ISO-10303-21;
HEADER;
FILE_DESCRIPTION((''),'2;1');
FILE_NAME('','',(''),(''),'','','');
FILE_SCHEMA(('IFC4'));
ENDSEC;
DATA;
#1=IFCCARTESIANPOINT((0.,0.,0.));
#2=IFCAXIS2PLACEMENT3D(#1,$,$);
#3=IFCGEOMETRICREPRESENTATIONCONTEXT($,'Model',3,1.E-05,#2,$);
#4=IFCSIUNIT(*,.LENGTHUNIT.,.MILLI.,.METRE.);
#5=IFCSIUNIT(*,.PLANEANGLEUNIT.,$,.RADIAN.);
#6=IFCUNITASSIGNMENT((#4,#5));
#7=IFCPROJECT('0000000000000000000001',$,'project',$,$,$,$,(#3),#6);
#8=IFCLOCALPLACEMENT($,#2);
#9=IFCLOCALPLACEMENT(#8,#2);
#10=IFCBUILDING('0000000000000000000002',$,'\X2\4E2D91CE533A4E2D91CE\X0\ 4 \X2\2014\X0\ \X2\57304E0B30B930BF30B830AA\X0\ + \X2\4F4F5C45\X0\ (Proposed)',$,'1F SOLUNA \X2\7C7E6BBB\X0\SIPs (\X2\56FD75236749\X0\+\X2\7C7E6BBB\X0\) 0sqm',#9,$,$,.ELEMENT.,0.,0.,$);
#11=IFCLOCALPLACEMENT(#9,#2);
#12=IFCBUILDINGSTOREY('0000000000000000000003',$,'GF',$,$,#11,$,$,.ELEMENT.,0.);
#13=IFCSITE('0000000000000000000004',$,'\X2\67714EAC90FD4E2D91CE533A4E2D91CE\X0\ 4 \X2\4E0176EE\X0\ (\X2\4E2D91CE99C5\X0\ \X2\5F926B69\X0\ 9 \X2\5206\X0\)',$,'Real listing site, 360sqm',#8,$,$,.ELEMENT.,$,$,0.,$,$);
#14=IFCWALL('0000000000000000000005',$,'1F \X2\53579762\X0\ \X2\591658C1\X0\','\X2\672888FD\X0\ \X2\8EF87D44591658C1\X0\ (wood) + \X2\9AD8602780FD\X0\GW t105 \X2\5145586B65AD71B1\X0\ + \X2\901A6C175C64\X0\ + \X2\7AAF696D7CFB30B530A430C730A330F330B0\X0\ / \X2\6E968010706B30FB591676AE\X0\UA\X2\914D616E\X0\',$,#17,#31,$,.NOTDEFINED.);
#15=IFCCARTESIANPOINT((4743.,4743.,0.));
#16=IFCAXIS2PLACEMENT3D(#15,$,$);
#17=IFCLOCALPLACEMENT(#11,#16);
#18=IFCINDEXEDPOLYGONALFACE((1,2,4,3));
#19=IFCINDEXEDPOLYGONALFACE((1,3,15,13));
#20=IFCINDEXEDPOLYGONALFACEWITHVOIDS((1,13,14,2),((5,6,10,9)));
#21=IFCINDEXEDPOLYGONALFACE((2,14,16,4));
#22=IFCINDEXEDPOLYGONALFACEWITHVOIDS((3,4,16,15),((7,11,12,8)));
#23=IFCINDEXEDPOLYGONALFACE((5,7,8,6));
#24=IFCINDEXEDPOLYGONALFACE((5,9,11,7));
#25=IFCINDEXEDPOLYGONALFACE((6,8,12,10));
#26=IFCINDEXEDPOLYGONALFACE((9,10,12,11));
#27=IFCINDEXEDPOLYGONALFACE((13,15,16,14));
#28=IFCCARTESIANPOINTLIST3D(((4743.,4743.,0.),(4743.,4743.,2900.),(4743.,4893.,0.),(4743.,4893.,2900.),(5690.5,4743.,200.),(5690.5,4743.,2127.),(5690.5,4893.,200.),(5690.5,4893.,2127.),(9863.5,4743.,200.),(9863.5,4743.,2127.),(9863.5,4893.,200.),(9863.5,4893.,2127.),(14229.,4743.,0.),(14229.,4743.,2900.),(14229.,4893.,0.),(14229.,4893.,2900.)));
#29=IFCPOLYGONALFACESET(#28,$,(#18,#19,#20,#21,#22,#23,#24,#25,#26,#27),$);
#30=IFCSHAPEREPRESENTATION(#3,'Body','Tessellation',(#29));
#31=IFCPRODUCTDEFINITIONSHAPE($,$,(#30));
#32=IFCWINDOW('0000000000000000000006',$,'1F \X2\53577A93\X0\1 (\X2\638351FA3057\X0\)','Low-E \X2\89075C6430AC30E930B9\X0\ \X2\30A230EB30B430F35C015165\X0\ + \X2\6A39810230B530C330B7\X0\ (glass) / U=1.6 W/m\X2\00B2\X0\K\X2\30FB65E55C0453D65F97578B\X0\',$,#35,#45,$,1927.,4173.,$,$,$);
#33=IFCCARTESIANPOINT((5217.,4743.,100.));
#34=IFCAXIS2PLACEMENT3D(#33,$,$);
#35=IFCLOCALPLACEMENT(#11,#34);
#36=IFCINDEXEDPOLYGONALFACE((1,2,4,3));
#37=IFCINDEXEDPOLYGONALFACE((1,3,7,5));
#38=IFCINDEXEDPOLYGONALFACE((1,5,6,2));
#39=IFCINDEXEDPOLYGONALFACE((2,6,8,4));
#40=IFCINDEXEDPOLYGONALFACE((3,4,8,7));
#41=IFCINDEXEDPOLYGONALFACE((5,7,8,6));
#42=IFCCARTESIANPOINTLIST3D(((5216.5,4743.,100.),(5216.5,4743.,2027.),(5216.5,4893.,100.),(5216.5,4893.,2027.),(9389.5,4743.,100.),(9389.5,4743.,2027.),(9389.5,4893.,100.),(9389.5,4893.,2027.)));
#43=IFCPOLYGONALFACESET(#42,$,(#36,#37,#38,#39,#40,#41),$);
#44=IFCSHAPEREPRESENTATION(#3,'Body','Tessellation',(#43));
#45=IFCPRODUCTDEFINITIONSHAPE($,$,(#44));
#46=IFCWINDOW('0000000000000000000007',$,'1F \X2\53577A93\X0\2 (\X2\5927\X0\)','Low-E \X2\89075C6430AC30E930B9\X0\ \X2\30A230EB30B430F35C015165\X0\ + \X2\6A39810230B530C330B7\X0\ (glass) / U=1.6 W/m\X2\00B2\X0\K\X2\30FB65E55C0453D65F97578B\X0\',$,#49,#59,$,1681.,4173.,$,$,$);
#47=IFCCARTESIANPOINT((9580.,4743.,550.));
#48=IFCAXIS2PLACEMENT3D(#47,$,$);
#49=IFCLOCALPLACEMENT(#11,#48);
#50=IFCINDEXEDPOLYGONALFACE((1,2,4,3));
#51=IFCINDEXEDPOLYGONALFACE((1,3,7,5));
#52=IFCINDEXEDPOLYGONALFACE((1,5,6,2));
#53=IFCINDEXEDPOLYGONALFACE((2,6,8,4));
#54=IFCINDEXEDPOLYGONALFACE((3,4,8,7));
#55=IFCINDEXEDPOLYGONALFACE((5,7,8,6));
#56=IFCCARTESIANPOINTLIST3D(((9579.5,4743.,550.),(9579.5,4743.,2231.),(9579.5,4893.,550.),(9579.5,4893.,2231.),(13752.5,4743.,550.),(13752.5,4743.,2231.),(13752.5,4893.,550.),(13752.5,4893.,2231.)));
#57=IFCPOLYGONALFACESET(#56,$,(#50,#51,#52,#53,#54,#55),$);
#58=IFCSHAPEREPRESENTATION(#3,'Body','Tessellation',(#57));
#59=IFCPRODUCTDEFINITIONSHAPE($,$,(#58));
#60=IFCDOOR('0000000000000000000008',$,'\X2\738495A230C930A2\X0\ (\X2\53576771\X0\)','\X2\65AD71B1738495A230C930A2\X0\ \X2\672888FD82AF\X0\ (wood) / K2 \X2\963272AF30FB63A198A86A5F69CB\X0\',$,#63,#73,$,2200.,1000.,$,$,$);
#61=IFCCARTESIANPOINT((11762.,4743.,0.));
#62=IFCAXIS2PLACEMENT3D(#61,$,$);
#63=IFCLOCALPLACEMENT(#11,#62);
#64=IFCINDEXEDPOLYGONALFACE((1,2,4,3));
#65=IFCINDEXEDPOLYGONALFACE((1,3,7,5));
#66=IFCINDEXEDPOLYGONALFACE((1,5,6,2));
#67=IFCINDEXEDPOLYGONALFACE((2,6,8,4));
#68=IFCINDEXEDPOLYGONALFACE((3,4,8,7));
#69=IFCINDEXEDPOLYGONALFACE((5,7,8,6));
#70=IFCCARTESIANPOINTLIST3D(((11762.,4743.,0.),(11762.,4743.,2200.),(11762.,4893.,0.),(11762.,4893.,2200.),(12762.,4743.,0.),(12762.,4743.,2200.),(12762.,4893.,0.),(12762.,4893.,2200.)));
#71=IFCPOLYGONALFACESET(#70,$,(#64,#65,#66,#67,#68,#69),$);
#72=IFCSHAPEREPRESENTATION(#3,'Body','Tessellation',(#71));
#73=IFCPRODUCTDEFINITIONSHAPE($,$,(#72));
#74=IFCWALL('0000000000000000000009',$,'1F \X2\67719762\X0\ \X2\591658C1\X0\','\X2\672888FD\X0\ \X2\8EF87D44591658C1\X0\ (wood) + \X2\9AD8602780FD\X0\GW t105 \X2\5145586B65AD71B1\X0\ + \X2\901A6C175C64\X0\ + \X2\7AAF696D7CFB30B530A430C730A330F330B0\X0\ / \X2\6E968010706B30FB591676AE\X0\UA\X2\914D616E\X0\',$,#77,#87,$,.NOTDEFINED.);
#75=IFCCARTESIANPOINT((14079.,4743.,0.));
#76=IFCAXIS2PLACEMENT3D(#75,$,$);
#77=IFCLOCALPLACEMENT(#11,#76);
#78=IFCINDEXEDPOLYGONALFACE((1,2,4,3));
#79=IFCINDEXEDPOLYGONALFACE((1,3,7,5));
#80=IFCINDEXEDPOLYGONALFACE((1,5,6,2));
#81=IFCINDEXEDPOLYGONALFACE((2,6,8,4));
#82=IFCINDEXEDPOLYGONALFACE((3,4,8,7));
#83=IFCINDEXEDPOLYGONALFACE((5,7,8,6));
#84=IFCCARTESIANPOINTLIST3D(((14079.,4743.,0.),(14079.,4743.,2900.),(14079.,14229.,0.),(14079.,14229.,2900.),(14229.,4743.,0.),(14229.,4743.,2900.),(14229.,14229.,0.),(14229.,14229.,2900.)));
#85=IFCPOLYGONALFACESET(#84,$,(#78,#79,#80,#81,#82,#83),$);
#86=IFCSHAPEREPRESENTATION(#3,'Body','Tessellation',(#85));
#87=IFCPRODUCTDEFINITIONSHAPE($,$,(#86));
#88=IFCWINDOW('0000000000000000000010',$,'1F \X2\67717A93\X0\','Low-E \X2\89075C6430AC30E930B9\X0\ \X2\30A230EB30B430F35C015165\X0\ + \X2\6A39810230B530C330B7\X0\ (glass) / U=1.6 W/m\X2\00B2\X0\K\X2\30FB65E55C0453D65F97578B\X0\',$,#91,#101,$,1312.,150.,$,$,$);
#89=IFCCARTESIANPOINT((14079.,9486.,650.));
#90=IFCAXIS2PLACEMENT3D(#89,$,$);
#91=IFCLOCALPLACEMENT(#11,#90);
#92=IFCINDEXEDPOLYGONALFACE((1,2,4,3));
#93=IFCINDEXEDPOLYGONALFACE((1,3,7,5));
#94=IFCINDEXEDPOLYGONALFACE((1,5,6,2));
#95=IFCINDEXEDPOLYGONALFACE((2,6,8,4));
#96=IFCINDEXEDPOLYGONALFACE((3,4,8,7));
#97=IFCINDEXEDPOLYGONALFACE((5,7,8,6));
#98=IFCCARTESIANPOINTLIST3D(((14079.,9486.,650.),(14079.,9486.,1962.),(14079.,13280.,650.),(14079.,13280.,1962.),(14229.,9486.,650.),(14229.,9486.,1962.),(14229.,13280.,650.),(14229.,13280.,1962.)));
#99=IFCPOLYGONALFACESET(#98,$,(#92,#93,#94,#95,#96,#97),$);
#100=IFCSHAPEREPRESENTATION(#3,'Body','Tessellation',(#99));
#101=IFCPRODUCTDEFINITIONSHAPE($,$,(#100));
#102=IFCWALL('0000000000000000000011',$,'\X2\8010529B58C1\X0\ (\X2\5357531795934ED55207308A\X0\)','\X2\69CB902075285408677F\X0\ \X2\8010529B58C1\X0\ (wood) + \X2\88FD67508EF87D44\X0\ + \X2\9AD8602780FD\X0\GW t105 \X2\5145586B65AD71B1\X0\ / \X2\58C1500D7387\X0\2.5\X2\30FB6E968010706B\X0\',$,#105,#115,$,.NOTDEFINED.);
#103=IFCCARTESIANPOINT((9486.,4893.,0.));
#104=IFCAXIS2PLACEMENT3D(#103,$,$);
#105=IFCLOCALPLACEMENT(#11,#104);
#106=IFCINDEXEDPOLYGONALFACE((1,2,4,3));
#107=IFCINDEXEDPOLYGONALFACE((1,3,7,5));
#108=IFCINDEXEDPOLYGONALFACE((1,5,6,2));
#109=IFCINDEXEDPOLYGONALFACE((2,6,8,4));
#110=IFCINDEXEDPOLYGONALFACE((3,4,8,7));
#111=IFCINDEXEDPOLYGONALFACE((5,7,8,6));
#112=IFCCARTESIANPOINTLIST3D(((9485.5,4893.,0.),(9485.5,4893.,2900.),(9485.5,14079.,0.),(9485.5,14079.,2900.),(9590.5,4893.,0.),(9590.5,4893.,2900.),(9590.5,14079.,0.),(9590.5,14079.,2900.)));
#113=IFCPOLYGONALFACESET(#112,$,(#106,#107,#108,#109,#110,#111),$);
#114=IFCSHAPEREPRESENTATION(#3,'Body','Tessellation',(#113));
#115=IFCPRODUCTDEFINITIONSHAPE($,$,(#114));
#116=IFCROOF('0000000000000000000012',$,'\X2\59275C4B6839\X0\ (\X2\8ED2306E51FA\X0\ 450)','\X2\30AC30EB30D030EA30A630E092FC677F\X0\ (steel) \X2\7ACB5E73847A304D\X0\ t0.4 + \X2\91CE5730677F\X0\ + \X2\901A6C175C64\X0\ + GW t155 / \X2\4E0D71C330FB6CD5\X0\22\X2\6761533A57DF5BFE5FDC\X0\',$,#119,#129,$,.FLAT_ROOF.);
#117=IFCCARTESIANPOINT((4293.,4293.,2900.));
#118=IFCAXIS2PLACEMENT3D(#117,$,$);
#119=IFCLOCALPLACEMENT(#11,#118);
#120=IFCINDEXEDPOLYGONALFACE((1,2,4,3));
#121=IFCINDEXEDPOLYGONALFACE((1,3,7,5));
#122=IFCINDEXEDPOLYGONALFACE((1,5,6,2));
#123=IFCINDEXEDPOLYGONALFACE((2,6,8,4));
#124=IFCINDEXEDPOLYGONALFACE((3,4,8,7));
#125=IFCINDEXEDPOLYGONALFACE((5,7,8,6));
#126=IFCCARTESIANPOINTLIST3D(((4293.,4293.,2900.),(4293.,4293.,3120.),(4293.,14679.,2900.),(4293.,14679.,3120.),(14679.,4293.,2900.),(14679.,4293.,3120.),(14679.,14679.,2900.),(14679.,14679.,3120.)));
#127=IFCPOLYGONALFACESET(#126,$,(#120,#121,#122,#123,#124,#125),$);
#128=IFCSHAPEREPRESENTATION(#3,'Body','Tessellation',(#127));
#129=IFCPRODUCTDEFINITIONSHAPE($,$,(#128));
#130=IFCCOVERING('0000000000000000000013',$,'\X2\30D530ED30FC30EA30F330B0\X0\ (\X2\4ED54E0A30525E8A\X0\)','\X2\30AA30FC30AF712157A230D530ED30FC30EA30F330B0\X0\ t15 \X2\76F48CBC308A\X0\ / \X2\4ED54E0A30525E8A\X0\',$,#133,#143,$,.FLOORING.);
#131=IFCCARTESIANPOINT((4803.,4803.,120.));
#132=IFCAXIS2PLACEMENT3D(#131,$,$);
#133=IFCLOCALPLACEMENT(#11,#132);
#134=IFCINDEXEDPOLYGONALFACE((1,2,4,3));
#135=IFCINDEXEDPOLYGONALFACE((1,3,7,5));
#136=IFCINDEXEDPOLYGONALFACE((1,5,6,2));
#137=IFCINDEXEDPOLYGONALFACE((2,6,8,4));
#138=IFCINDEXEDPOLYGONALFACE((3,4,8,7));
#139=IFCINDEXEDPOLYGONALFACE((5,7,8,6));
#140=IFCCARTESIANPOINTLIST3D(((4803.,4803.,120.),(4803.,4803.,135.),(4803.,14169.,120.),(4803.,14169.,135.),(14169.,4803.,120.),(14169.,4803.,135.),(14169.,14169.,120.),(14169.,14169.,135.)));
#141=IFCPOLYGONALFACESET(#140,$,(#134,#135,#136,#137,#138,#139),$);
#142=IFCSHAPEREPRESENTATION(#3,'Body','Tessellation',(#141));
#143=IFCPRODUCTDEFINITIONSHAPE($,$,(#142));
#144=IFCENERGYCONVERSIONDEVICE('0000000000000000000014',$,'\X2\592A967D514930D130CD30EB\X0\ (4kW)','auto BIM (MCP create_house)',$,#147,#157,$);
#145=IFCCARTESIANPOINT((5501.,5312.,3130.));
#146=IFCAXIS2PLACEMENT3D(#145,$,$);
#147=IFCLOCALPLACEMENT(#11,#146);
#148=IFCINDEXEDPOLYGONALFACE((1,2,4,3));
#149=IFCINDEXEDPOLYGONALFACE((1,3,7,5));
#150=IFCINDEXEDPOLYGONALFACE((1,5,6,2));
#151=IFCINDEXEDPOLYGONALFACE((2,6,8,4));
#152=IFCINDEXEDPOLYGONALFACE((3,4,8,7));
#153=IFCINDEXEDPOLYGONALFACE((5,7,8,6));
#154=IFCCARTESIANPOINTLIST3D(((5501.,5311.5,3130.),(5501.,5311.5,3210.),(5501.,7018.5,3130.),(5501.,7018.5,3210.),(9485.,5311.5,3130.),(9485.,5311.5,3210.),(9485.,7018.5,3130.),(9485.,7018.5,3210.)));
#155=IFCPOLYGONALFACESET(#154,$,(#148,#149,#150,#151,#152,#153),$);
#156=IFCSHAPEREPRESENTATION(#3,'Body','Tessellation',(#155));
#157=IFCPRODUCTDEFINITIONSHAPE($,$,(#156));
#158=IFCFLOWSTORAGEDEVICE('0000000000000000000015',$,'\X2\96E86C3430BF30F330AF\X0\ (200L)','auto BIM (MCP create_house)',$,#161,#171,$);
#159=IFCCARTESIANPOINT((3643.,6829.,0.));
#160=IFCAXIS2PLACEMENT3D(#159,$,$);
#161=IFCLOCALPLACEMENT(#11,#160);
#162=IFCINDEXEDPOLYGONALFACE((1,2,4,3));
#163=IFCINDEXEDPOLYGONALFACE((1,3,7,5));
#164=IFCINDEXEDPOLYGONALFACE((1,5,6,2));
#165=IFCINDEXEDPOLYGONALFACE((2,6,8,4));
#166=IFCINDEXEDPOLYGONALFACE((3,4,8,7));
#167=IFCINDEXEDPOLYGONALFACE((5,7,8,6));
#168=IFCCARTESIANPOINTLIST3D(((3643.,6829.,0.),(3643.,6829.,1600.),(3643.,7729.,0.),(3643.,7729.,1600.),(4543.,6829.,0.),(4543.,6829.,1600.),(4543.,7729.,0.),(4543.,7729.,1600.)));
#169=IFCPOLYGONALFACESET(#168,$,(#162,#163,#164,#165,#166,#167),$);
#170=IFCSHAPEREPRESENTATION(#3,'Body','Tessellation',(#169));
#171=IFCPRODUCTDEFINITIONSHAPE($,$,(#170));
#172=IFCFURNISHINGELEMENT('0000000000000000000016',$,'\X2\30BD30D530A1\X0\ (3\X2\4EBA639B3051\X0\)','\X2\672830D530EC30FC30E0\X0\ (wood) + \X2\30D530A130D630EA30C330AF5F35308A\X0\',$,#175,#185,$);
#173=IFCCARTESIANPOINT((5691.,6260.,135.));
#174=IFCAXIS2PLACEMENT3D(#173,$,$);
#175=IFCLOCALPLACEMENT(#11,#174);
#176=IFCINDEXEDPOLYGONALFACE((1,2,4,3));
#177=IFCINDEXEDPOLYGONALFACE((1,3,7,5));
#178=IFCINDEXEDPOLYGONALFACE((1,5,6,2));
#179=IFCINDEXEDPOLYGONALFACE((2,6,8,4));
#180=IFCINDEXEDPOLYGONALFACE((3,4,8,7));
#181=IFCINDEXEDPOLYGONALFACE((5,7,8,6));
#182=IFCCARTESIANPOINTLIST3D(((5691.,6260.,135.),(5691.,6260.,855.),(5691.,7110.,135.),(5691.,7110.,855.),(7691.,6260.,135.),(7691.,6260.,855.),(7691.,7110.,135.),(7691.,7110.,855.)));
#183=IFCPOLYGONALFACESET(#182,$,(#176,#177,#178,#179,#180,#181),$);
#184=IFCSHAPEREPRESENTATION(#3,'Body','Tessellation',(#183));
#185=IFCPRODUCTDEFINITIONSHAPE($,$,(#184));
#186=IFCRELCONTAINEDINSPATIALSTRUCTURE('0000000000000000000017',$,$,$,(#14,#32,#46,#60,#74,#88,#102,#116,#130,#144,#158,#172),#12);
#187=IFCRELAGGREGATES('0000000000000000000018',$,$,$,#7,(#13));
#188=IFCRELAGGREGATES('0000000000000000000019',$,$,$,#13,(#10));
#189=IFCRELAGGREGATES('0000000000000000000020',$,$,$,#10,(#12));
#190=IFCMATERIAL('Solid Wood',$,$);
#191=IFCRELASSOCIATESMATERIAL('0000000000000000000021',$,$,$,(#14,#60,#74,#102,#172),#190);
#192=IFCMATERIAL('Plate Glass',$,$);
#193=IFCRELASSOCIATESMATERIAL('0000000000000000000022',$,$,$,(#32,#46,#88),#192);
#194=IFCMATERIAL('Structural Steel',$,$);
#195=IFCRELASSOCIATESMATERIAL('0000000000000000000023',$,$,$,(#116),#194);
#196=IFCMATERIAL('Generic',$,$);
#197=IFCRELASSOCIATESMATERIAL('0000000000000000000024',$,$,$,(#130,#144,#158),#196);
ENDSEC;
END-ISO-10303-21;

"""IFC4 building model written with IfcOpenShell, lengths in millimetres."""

from ifc_helpers import new_model, si_unit, frame, frame_2d, origin, place, context, project, spatial, rectangle, extrude, material, element, fill, save


model = new_model("IFC4")

# Units and contexts
model_context = context("Model", 3, precision=1e-05, world=origin())
ifc_project = project(units=[si_unit("LENGTHUNIT", "METRE", prefix="MILLI"), si_unit("PLANEANGLEUNIT", "RADIAN")], contexts=[model_context])

# Site, building, storey
site_placement = place(None, origin())
site = spatial("IfcSite", under=ifc_project, at=site_placement, Name="東京都中野区中野 4 丁目 (中野駅 徒歩 9 分)", ObjectType="Real listing site, 360sqm", CompositionType="ELEMENT", RefElevation=0.0)
building_placement = place(site_placement, origin())
building = spatial("IfcBuilding", under=site, at=building_placement, Name="中野区中野 4 — 地下スタジオ + 住居 (Proposed)", ObjectType="1F SOLUNA 籾殻SIPs (国産杉+籾殻) 0sqm", CompositionType="ELEMENT", ElevationOfRefHeight=0.0, ElevationOfTerrain=0.0)
storey_placement = place(building_placement, origin())
storey = spatial("IfcBuildingStorey", under=building, at=storey_placement, Name="GF", CompositionType="ELEMENT", Elevation=0.0)

# Shared definitions
ifc_material_1 = material(Name="Solid Wood")

# Wall, openings, windows, door
wall_1_placement = place(storey_placement, frame((4743.0, 4743.0, 0.0)))
wall_1 = element("IfcWall", 1, at=wall_1_placement, inside=storey, material=ifc_material_1, Name="1F 南面 外壁", Description="木製 軸組外壁 (wood) + 高性能GW t105 充填断熱 + 通気層 + 窯業系サイディング / 準耐火・外皮UA配慮", PredefinedType="NOTDEFINED", context=model_context, shape_type="SweptSolid", body=[
    extrude(rectangle(XDim=9486.0, YDim=150.0, at=frame_2d((4743.0, 75.0))), frame((4743.0, 4743.0, 0.0)), (0.0, 0.0, 1.0), 2900.0),
])
opening_1_placement = place(storey_placement, frame((5217.0, 4743.0, 100.0)))
opening_1 = element("IfcOpeningElement", 2, at=opening_1_placement, cuts=wall_1, PredefinedType="NOTDEFINED", context=model_context, shape_type="SweptSolid", body=[
    extrude(rectangle(XDim=4173.0, YDim=150.0, at=frame_2d((2086.0, 75.0))), frame((5217.0, 4743.0, 100.0)), (0.0, 0.0, 1.0), 1927.0),
])
opening_2_placement = place(storey_placement, frame((9580.0, 4743.0, 550.0)))
opening_2 = element("IfcOpeningElement", 3, at=opening_2_placement, cuts=wall_1, PredefinedType="NOTDEFINED", context=model_context, shape_type="SweptSolid", body=[
    extrude(rectangle(XDim=4173.0, YDim=150.0, at=frame_2d((2086.0, 75.0))), frame((9580.0, 4743.0, 550.0)), (0.0, 0.0, 1.0), 1681.0),
])
opening_3_placement = place(storey_placement, frame((11762.0, 4743.0, 0.0)))
opening_3 = element("IfcOpeningElement", 4, at=opening_3_placement, cuts=wall_1, PredefinedType="NOTDEFINED", context=model_context, shape_type="SweptSolid", body=[
    extrude(rectangle(XDim=1000.0, YDim=150.0, at=frame_2d((500.0, 75.0))), frame((11762.0, 4743.0, 0.0)), (0.0, 0.0, 1.0), 2200.0),
])
ifc_material_2 = material(Name="Plate Glass")
window_1_placement = place(storey_placement, frame((5217.0, 4743.0, 100.0)))
window_1 = element("IfcWindow", 5, at=window_1_placement, inside=storey, material=ifc_material_2, Name="1F 南窓1 (掃出し)", Description="Low-E 複層ガラス アルゴン封入 + 樹脂サッシ (glass) / U=1.6 W/m²K・日射取得型", OverallHeight=1927.0, OverallWidth=4173.0, context=model_context, shape_type="SweptSolid", body=[
    extrude(rectangle(XDim=4173.0, YDim=150.0, at=frame_2d((2086.0, 75.0))), frame((5217.0, 4743.0, 100.0)), (0.0, 0.0, 1.0), 1927.0),
])
fill(opening_1, window_1)
window_2_placement = place(storey_placement, frame((9580.0, 4743.0, 550.0)))
window_2 = element("IfcWindow", 6, at=window_2_placement, inside=storey, material=ifc_material_2, Name="1F 南窓2 (大)", Description="Low-E 複層ガラス アルゴン封入 + 樹脂サッシ (glass) / U=1.6 W/m²K・日射取得型", OverallHeight=1681.0, OverallWidth=4173.0, context=model_context, shape_type="SweptSolid", body=[
    extrude(rectangle(XDim=4173.0, YDim=150.0, at=frame_2d((2086.0, 75.0))), frame((9580.0, 4743.0, 550.0)), (0.0, 0.0, 1.0), 1681.0),
])
fill(opening_2, window_2)
door_placement = place(storey_placement, frame((11762.0, 4743.0, 0.0)))
door = element("IfcDoor", 7, at=door_placement, inside=storey, material=ifc_material_1, Name="玄関ドア (南東)", Description="断熱玄関ドア 木製芯 (wood) / K2 防犯・採風機構", OverallHeight=2200.0, OverallWidth=1000.0, context=model_context, shape_type="SweptSolid", body=[
    extrude(rectangle(XDim=1000.0, YDim=150.0, at=frame_2d((500.0, 75.0))), frame((11762.0, 4743.0, 0.0)), (0.0, 0.0, 1.0), 2200.0),
])
fill(opening_3, door)

# Wall, opening, window
wall_2_placement = place(storey_placement, frame((14079.0, 4743.0, 0.0)))
wall_2 = element("IfcWall", 8, at=wall_2_placement, inside=storey, material=ifc_material_1, Name="1F 東面 外壁", Description="木製 軸組外壁 (wood) + 高性能GW t105 充填断熱 + 通気層 + 窯業系サイディング / 準耐火・外皮UA配慮", PredefinedType="NOTDEFINED", context=model_context, shape_type="SweptSolid", body=[
    extrude(rectangle(XDim=150.0, YDim=9486.0, at=frame_2d((75.0, 4743.0))), frame((14079.0, 4743.0, 0.0)), (0.0, 0.0, 1.0), 2900.0),
])
opening_4_placement = place(storey_placement, frame((14079.0, 9486.0, 650.0)))
opening_4 = element("IfcOpeningElement", 9, at=opening_4_placement, cuts=wall_2, PredefinedType="NOTDEFINED", context=model_context, shape_type="SweptSolid", body=[
    extrude(rectangle(XDim=150.0, YDim=3794.0, at=frame_2d((75.0, 1897.0))), frame((14079.0, 9486.0, 650.0)), (0.0, 0.0, 1.0), 1312.0),
])
window_3_placement = place(storey_placement, frame((14079.0, 9486.0, 650.0)))
window_3 = element("IfcWindow", 10, at=window_3_placement, inside=storey, material=ifc_material_2, Name="1F 東窓", Description="Low-E 複層ガラス アルゴン封入 + 樹脂サッシ (glass) / U=1.6 W/m²K・日射取得型", OverallHeight=1312.0, OverallWidth=150.0, context=model_context, shape_type="SweptSolid", body=[
    extrude(rectangle(XDim=150.0, YDim=3794.0, at=frame_2d((75.0, 1897.0))), frame((14079.0, 9486.0, 650.0)), (0.0, 0.0, 1.0), 1312.0),
])
fill(opening_4, window_3)

# Wall
wall_3_placement = place(storey_placement, frame((9486.0, 4893.0, 0.0)))
element("IfcWall", 11, at=wall_3_placement, inside=storey, material=ifc_material_1, Name="耐力壁 (南北間仕切り)", Description="構造用合板 耐力壁 (wood) + 製材軸組 + 高性能GW t105 充填断熱 / 壁倍率2.5・準耐火", PredefinedType="NOTDEFINED", context=model_context, shape_type="SweptSolid", body=[
    extrude(rectangle(XDim=105.0, YDim=9186.0, at=frame_2d((52.0, 4593.0))), frame((9486.0, 4893.0, 0.0)), (0.0, 0.0, 1.0), 2900.0),
])

# Roof
ifc_material_3 = material(Name="Structural Steel")
roof_placement = place(storey_placement, frame((4293.0, 4293.0, 2900.0)))
element("IfcRoof", 12, at=roof_placement, inside=storey, material=ifc_material_3, Name="大屋根 (軒の出 450)", Description="ガルバリウム鋼板 (steel) 立平葺き t0.4 + 野地板 + 通気層 + GW t155 / 不燃・法22条区域対応", PredefinedType="FLAT_ROOF", context=model_context, shape_type="SweptSolid", body=[
    extrude(rectangle(XDim=10386.0, YDim=10386.0, at=frame_2d((5193.0, 5193.0))), frame((4293.0, 4293.0, 2900.0)), (0.0, 0.0, 1.0), 220.0),
])

# Covering
ifc_material_4 = material(Name="Generic")
covering_placement = place(storey_placement, frame((4803.0, 4803.0, 120.0)))
element("IfcCovering", 13, at=covering_placement, inside=storey, material=ifc_material_4, Name="フローリング (仕上げ床)", Description="オーク無垢フローリング t15 直貼り / 仕上げ床", PredefinedType="FLOORING", context=model_context, shape_type="SweptSolid", body=[
    extrude(rectangle(XDim=9366.0, YDim=9366.0, at=frame_2d((4683.0, 4683.0))), frame((4803.0, 4803.0, 120.0)), (0.0, 0.0, 1.0), 15.0),
])

# Energy conversion device
energy_conversion_device_placement = place(storey_placement, frame((5501.0, 5312.0, 3130.0)))
element("IfcEnergyConversionDevice", 14, at=energy_conversion_device_placement, inside=storey, material=ifc_material_4, Name="太陽光パネル (4kW)", Description="auto BIM (MCP create_house)", context=model_context, shape_type="SweptSolid", body=[
    extrude(rectangle(XDim=3984.0, YDim=1707.0, at=frame_2d((1992.0, 853.0))), frame((5501.0, 5312.0, 3130.0)), (0.0, 0.0, 1.0), 80.0),
])

# Flow storage device
flow_storage_device_placement = place(storey_placement, frame((3643.0, 6829.0, 0.0)))
element("IfcFlowStorageDevice", 15, at=flow_storage_device_placement, inside=storey, material=ifc_material_4, Name="雨水タンク (200L)", Description="auto BIM (MCP create_house)", context=model_context, shape_type="SweptSolid", body=[
    extrude(rectangle(XDim=900.0, YDim=900.0, at=frame_2d((450.0, 450.0))), frame((3643.0, 6829.0, 0.0)), (0.0, 0.0, 1.0), 1600.0),
])

# Furnishing element
furnishing_1_placement = place(storey_placement, frame((5691.0, 6260.0, 135.0)))
element("IfcFurnishingElement", 16, at=furnishing_1_placement, inside=storey, material=ifc_material_1, Name="ソファ (3人掛け)", Description="木フレーム (wood) + ファブリック張り", context=model_context, shape_type="SweptSolid", body=[
    extrude(rectangle(XDim=2000.0, YDim=850.0, at=frame_2d((1000.0, 425.0))), frame((5691.0, 6260.0, 135.0)), (0.0, 0.0, 1.0), 720.0),
])

save(model, "model.ifc")
